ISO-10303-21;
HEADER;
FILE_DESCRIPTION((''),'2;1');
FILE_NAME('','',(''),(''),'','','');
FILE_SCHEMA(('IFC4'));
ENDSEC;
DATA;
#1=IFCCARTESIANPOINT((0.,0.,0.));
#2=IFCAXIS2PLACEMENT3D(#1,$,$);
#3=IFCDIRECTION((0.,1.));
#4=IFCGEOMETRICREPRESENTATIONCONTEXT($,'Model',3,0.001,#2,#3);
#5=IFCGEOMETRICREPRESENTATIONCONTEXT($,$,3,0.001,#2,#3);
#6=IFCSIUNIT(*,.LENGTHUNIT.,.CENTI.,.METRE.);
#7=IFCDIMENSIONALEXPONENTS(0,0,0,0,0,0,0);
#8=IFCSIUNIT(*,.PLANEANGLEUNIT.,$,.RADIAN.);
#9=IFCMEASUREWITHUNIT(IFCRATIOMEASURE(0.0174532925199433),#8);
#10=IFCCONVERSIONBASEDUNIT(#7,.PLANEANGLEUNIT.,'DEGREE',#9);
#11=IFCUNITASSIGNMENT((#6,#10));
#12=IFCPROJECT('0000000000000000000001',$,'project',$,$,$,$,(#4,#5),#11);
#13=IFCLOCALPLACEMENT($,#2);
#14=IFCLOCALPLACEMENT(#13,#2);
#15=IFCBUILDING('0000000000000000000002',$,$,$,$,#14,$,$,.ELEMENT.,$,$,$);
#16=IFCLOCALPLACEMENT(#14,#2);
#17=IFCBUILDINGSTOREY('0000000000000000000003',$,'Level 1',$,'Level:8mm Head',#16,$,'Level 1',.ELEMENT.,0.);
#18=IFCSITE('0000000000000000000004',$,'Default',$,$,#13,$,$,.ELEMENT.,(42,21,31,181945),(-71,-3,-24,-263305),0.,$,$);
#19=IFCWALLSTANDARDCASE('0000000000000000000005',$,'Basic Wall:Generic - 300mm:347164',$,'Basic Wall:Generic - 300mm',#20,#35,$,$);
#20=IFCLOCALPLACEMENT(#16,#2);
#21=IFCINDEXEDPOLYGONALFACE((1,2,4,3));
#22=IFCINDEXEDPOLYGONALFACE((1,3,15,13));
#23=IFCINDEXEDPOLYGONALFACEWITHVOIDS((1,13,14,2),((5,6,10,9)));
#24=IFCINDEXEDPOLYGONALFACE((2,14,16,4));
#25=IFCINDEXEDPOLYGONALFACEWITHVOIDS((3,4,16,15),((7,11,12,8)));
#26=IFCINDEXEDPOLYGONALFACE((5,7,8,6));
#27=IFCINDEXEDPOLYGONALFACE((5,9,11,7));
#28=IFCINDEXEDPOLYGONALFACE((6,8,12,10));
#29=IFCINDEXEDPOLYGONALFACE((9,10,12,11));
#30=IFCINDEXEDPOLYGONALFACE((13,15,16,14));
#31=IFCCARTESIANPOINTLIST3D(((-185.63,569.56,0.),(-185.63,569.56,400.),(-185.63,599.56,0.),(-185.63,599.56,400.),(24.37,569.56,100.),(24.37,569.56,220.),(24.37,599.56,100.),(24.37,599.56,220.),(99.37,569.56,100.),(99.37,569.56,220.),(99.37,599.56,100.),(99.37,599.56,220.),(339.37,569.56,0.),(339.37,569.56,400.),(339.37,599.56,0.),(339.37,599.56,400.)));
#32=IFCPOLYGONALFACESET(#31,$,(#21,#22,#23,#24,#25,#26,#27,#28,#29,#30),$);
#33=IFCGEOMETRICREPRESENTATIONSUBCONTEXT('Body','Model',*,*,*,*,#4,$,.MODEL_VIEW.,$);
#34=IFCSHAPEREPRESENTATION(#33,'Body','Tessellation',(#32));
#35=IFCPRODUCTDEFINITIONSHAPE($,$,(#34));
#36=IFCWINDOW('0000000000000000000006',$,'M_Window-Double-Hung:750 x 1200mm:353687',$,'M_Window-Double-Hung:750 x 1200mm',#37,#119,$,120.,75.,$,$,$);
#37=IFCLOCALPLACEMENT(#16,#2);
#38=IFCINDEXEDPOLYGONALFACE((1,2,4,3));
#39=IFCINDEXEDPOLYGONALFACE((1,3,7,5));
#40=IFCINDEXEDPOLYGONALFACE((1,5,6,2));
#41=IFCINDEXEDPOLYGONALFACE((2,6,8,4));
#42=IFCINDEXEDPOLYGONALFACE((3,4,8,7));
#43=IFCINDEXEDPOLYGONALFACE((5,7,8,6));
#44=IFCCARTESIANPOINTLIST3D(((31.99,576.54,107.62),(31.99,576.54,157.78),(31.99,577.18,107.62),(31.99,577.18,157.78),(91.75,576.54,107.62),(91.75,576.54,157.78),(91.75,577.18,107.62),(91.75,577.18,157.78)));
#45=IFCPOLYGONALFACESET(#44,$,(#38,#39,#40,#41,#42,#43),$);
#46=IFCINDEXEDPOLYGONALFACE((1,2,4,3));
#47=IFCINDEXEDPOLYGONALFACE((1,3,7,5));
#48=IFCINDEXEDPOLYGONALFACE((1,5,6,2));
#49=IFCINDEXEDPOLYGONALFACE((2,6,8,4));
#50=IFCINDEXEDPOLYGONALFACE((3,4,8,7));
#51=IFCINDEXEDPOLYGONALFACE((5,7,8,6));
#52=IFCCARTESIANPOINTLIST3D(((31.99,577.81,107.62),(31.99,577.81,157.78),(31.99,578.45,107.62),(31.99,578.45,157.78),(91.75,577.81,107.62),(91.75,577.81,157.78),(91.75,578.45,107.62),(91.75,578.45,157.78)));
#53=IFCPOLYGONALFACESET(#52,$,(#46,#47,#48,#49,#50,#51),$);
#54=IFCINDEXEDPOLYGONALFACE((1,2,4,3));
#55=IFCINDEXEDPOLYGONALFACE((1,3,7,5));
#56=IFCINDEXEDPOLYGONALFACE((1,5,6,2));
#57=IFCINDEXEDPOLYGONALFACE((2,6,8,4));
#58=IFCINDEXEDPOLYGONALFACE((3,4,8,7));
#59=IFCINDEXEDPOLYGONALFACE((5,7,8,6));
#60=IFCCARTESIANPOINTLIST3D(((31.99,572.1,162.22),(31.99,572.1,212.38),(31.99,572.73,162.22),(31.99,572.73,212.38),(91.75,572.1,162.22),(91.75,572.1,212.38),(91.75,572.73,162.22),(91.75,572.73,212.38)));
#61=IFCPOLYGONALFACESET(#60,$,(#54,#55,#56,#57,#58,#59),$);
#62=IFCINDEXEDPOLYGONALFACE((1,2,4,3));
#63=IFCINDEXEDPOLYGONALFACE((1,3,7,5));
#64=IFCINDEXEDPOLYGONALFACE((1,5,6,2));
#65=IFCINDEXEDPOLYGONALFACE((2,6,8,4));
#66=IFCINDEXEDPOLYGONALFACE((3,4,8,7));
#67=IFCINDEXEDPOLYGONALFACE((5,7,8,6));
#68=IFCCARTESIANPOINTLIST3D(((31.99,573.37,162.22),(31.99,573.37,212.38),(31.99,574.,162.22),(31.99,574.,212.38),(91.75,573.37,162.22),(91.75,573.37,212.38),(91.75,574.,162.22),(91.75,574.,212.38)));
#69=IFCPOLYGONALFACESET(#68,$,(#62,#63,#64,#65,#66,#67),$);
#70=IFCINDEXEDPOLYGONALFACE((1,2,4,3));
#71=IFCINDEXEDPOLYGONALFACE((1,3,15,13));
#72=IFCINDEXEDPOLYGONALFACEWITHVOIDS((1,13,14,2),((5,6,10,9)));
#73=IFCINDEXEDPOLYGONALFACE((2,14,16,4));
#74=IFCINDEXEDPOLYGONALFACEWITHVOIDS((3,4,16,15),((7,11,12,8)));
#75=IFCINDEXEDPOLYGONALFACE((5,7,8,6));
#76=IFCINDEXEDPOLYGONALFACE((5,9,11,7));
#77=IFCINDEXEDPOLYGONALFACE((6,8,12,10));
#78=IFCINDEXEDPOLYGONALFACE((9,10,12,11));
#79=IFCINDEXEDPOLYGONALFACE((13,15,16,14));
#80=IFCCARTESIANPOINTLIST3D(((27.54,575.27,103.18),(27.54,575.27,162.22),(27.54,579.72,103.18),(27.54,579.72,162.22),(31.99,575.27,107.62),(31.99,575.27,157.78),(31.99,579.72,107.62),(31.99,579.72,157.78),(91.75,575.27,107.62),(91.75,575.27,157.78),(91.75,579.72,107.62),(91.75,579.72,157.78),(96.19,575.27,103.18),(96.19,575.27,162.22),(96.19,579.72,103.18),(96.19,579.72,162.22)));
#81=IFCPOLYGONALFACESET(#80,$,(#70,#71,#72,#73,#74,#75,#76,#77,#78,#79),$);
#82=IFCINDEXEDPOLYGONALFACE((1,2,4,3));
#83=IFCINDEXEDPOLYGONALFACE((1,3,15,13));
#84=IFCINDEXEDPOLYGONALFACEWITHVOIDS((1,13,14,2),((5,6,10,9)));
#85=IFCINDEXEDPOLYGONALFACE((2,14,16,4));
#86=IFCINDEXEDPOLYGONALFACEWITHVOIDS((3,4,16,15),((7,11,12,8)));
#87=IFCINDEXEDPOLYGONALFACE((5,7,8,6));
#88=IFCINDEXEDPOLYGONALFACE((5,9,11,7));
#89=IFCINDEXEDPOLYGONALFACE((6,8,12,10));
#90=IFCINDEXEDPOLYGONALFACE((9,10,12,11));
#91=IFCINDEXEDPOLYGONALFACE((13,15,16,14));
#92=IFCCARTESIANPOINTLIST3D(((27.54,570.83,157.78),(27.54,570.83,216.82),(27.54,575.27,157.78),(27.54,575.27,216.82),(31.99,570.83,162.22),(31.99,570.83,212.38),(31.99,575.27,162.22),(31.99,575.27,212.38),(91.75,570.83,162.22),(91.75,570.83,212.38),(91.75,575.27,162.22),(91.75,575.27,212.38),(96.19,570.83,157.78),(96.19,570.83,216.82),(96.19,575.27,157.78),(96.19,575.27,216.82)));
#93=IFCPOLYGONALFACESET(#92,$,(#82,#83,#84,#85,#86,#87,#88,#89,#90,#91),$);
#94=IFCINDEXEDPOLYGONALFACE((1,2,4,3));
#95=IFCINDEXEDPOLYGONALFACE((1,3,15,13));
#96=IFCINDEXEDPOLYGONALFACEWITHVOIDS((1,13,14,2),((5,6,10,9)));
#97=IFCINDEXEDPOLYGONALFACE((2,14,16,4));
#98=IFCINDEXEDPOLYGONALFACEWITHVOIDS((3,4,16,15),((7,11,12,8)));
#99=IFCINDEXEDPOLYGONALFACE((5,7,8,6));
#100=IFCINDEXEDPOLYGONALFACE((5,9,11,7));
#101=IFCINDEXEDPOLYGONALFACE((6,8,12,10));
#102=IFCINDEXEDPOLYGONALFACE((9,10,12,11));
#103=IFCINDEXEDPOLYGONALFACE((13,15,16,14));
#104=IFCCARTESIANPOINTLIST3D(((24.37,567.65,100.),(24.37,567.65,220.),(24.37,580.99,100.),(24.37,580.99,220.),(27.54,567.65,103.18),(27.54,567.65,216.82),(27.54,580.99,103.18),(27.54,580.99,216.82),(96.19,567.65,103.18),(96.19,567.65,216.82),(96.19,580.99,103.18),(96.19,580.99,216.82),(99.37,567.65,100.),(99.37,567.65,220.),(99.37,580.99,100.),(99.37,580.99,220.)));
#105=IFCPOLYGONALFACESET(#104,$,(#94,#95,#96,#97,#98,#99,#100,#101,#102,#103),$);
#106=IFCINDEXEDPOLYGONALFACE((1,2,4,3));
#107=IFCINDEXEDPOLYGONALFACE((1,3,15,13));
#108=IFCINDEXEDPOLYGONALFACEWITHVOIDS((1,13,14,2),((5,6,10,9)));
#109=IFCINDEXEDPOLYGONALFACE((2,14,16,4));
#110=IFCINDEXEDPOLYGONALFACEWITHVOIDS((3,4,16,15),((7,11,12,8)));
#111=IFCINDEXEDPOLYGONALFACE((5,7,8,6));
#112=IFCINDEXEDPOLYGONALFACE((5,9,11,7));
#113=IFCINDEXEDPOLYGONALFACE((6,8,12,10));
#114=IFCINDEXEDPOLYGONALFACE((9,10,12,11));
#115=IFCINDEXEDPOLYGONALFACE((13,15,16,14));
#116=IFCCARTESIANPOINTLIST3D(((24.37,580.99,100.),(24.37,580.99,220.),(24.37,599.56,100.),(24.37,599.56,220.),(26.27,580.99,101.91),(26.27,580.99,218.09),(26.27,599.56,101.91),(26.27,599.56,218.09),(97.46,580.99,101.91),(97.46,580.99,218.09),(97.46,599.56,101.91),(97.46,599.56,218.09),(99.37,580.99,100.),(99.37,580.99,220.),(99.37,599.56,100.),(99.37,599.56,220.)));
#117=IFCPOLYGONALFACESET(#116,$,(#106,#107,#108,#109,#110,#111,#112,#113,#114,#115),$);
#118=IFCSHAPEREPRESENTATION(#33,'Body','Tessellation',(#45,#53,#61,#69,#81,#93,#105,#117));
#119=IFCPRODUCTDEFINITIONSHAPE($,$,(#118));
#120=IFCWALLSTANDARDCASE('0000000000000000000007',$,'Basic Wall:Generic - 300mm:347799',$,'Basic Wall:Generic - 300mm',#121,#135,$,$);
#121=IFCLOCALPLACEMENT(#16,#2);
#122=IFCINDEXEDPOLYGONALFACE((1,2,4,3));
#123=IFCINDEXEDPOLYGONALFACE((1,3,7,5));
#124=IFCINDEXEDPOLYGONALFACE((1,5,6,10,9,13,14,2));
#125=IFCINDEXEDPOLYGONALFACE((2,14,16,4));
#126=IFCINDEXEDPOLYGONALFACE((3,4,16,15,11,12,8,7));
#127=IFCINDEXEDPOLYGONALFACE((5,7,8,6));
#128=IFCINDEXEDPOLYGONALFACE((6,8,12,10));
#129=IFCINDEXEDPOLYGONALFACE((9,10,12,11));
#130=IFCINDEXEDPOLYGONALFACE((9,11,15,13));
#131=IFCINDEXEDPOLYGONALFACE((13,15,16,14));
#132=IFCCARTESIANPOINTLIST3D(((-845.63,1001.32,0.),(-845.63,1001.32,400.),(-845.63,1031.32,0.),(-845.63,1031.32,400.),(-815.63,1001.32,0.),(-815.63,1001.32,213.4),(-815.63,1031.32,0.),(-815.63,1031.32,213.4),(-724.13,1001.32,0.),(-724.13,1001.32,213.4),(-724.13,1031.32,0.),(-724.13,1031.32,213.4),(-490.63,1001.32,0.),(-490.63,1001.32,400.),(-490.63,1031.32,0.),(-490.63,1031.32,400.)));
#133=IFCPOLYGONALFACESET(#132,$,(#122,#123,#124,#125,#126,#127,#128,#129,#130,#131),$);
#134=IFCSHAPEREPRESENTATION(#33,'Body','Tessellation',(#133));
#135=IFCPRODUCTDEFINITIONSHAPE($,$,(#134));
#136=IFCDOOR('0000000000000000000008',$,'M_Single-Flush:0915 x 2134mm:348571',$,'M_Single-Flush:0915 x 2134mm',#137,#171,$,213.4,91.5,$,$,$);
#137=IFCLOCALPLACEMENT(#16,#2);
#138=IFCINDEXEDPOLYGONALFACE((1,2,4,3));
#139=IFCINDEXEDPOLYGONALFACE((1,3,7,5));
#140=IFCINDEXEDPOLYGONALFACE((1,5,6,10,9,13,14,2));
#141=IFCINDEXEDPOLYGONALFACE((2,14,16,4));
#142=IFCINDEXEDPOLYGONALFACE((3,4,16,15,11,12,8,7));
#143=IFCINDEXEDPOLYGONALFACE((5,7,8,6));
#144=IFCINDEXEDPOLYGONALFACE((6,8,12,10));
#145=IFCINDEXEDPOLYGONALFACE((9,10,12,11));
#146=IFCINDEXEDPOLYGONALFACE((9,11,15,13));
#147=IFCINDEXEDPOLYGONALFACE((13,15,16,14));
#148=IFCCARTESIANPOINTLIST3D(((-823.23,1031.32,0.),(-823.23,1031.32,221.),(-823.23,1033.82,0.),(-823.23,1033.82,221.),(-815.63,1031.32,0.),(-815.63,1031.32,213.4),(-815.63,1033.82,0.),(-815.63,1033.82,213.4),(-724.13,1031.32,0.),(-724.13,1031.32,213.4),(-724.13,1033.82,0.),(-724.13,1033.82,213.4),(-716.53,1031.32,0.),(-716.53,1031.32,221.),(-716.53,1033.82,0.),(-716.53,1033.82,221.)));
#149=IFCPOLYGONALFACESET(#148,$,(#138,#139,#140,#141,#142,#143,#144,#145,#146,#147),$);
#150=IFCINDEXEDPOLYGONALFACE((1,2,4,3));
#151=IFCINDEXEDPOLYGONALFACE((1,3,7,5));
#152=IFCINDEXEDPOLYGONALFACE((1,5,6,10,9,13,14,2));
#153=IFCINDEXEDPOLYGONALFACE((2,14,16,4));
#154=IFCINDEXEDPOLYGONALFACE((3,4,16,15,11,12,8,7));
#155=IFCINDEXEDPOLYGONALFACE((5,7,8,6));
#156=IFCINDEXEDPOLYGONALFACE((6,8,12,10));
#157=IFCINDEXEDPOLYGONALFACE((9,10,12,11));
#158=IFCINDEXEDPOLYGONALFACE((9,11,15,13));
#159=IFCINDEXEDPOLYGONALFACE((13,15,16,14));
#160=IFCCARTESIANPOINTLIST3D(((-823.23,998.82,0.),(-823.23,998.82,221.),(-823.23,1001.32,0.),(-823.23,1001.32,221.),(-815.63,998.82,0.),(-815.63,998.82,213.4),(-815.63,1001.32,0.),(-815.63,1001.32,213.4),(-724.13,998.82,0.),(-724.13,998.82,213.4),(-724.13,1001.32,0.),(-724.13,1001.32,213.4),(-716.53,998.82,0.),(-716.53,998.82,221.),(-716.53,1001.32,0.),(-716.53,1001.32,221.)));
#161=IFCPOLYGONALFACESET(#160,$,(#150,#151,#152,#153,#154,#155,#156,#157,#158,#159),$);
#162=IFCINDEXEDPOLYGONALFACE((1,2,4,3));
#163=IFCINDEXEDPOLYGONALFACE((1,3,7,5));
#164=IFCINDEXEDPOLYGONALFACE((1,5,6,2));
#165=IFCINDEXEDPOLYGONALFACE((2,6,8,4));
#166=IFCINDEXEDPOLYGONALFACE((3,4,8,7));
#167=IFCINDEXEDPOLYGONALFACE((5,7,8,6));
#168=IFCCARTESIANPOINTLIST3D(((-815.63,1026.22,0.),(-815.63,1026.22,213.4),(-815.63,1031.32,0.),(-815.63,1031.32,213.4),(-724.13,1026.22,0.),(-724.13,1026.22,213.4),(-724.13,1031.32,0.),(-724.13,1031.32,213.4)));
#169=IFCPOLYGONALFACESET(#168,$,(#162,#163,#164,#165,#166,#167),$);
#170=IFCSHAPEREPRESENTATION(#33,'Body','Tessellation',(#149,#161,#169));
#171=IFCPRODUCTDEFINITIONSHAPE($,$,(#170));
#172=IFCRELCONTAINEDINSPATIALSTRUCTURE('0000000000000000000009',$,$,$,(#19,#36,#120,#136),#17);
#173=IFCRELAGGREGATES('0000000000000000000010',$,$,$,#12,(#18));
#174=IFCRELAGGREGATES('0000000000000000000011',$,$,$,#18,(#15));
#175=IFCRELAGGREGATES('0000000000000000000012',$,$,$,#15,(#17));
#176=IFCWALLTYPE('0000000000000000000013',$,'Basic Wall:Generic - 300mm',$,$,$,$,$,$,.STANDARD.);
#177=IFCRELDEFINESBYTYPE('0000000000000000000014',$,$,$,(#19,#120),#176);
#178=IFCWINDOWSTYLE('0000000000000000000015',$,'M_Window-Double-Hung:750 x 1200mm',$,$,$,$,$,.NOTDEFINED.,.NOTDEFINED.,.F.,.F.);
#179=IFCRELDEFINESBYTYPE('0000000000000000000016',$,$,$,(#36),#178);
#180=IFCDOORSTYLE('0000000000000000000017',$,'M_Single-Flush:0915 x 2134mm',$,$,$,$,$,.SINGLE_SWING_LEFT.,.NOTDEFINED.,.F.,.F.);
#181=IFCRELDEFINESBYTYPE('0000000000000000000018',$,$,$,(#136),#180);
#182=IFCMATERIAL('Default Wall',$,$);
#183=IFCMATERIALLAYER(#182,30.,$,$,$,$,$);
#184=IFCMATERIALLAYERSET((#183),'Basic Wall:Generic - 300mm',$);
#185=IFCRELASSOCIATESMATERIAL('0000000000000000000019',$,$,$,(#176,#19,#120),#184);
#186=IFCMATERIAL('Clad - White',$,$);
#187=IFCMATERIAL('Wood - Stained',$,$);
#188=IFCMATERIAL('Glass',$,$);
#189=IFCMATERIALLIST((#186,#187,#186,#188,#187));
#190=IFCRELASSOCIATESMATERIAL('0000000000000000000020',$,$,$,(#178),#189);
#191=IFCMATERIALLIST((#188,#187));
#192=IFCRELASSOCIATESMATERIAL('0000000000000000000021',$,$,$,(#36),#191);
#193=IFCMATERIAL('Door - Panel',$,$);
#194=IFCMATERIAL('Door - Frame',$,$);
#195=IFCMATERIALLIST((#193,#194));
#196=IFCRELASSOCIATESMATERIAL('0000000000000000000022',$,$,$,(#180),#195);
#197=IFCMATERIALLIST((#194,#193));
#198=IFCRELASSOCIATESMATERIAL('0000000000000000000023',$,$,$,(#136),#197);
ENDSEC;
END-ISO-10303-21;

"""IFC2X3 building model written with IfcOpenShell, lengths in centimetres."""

from ifc_helpers import new_model, entity, si_unit, converted_unit, direction, frame, frame_2d, origin, origin_2d_with_axis, place, context, subcontext, project, spatial, polyline, rectangle, outline, extrude, source, transform, mapped, material, material_list, layer, layer_set, layer_usage, type_object, type_shapes, element, fill, save


model = new_model("IFC2X3")

# Units and contexts
model_context = context("Model", 3, precision=0.001, world=origin(), true_north=direction((0.0, 1.0)))
context_of_model = context(None, 3, precision=0.001, world=origin(), true_north=direction((0.0, 1.0)))
body_context = subcontext(model_context, "Body", "Model", "MODEL_VIEW")
ifc_project = project(units=[si_unit("LENGTHUNIT", "METRE", prefix="CENTI"), converted_unit("PLANEANGLEUNIT", "DEGREE", entity("IfcRatioMeasure", 0.0174532925199433), si_unit("PLANEANGLEUNIT", "RADIAN"), dimensions=[0, 0, 0, 0, 0, 0, 0])], contexts=[model_context, context_of_model])

# Site, building, storey
site_placement = place(None, origin())
site = spatial("IfcSite", under=ifc_project, at=site_placement, Name="Default", CompositionType="ELEMENT", RefLatitude=(42, 21, 31, 181945), RefLongitude=(-71, -3, -24, -263305), RefElevation=0.0)
building_placement = place(site_placement, origin())
building = spatial("IfcBuilding", under=site, at=building_placement, CompositionType="ELEMENT")
storey_placement = place(building_placement, origin())
storey = spatial("IfcBuildingStorey", under=building, at=storey_placement, Name="Level 1", ObjectType="Level:8mm Head", LongName="Level 1", CompositionType="ELEMENT", Elevation=0.0)

# Wall, opening, window
ifc_material_1 = material(Name="Default Wall")
ifc_layer_1 = layer(ifc_material_1, 30.0)
ifc_layer_set_1 = layer_set([ifc_layer_1], Name="Basic Wall:Generic - 300mm")
wall_type = type_object("IfcWallType", Name="Basic Wall:Generic - 300mm", PredefinedType="STANDARD", material=ifc_layer_set_1)
ifc_material_2 = material(Name="Glass")
ifc_material_3 = material(Name="Wood - Stained")
ifc_material_4 = material(Name="Clad - White")
ifc_material_list_1 = material_list([ifc_material_4, ifc_material_3, ifc_material_4, ifc_material_2, ifc_material_3])
window_style = type_object("IfcWindowStyle", Name="M_Window-Double-Hung:750 x 1200mm", ConstructionType="NOTDEFINED", OperationType="NOTDEFINED", ParameterTakesPrecedence=False, Sizeable=False, material=ifc_material_list_1)
shared_shape_1 = source(origin(), body_context, "Body", "SweptSolid", [
    extrude(rectangle(XDim=59.76, YDim=0.63, at=frame_2d((0.0, 0.0), x_axis=(1.0, 0.0))), frame((37.5, 22.7, 7.62), z_axis=(0.0, 0.0, 1.0), x_axis=(-1.0, 0.0, 0.0)), (0.0, 0.0, 1.0), 50.16),
    extrude(rectangle(XDim=0.63, YDim=59.76, at=origin_2d_with_axis()), frame((37.5, 21.43, 7.62), z_axis=(0.0, 0.0, 1.0), x_axis=(0.0, -1.0, 0.0)), (0.0, 0.0, 1.0), 50.16),
    extrude(rectangle(XDim=59.76, YDim=0.63, at=frame_2d((0.0, 0.0), x_axis=(1.0, 0.0))), frame((37.5, 27.14, 62.22), z_axis=(0.0, 0.0, 1.0), x_axis=(-1.0, 0.0, 0.0)), (0.0, 0.0, 1.0), 50.16),
    extrude(rectangle(XDim=0.63, YDim=59.76, at=frame_2d((0.0, 0.0), x_axis=(1.0, 0.0))), frame((37.5, 25.87, 62.22), z_axis=(0.0, 0.0, 1.0), x_axis=(0.0, -1.0, 0.0)), (0.0, 0.0, 1.0), 50.16),
    extrude(outline(polyline([(-34.32, -29.52), (34.32, -29.52), (34.32, 29.52), (-34.32, 29.52), (-34.32, -29.52)]), holes=[polyline([(29.88, -25.08), (-29.88, -25.08), (-29.88, 25.08), (29.88, 25.08), (29.88, -25.08)])]), frame((37.5, 19.84, 32.7), z_axis=(0.0, 1.0, 0.0), x_axis=(1.0, 0.0, 0.0)), (0.0, 0.0, 1.0), 4.45),
    extrude(outline(polyline([(-34.33, -29.52), (34.32, -29.52), (34.33, 29.52), (-34.32, 29.52), (-34.33, -29.52)]), holes=[polyline([(29.88, -25.08), (-29.88, -25.08), (-29.88, 25.08), (29.88, 25.08), (29.88, -25.08)])]), frame((37.5, 24.28, 87.3), z_axis=(0.0, 1.0, 0.0), x_axis=(1.0, 0.0, 0.0)), (0.0, 0.0, 1.0), 4.45),
    extrude(outline(polyline([(-37.5, -60.0), (37.5, -60.0), (37.5, 60.0), (-37.5, 60.0), (-37.5, -60.0)]), holes=[polyline([(34.32, -56.82), (-34.32, -56.82), (-34.32, 56.82), (34.32, 56.82), (34.32, -56.82)])]), frame((37.5, 18.57, 60.0), z_axis=(0.0, 1.0, 0.0), x_axis=(1.0, 0.0, 0.0)), (0.0, 0.0, 1.0), 13.33),
    extrude(outline(polyline([(-60.0, -37.5), (60.0, -37.5), (60.0, 37.5), (-60.0, 37.5), (-60.0, -37.5)]), holes=[polyline([(-58.09, -35.59), (-58.09, 35.59), (58.09, 35.59), (58.09, -35.59), (-58.09, -35.59)])]), frame((37.5, 0.0, 60.0), z_axis=(0.0, 1.0, 0.0), x_axis=(0.0, 0.0, -1.0)), (0.0, 0.0, 1.0), 18.57),
])
type_shapes(window_style, [shared_shape_1])
ifc_layer_usage_1 = layer_usage(ifc_layer_set_1, "AXIS2", "NEGATIVE", 15.0)
wall_1_placement = place(storey_placement, frame((339.37, 584.56, 0.0), z_axis=(0.0, 0.0, 1.0), x_axis=(-1.0, 0.0, 0.0)))
wall_1 = element("IfcWallStandardCase", 1, at=wall_1_placement, inside=storey, type_object=wall_type, material=ifc_layer_usage_1, Name="Basic Wall:Generic - 300mm:347164", ObjectType="Basic Wall:Generic - 300mm", context=body_context, shape_type="SweptSolid", body=[
    extrude(rectangle(XDim=525.0, YDim=30.0, at=frame_2d((262.5, 0.0), x_axis=(-1.0, 0.0))), origin(), (0.0, 0.0, 1.0), 400.0),
])
opening_1_placement = place(wall_1_placement, frame((240.0, -15.0, 100.0)))
opening_1 = element("IfcOpeningElement", 2, at=opening_1_placement, cuts=wall_1, ObjectType="Opening", context=body_context, shape_type="SweptSolid", body=[
    extrude(rectangle(XDim=120.0, YDim=75.0, at=frame_2d((60.0, 37.5), x_axis=(-1.0, 0.0))), frame((0.0, 0.0, 0.0), z_axis=(0.0, 1.0, 0.0), x_axis=(0.0, 0.0, 1.0)), (0.0, 0.0, 1.0), 30.0),
])
ifc_material_list_2 = material_list([ifc_material_2, ifc_material_3])
window_1_placement = place(opening_1_placement, origin())
window_1 = element("IfcWindow", 3, at=window_1_placement, inside=storey, type_object=window_style, material=ifc_material_list_2, Name="M_Window-Double-Hung:750 x 1200mm:353687", ObjectType="M_Window-Double-Hung:750 x 1200mm", OverallHeight=120.0, OverallWidth=75.0, context=body_context, shape_type="MappedRepresentation", body=[
    mapped(shared_shape_1, transform((0.0, 0.0, 0.0), scale=1.0)),
])
fill(opening_1, window_1)

# Wall, opening, door
ifc_layer_usage_2 = layer_usage(ifc_layer_set_1, "AXIS2", "POSITIVE", -15.0)
wall_2_placement = place(storey_placement, frame((-845.63, 1016.32, 0.0)))
wall_2 = element("IfcWallStandardCase", 4, at=wall_2_placement, inside=storey, type_object=wall_type, material=ifc_layer_usage_2, Name="Basic Wall:Generic - 300mm:347799", ObjectType="Basic Wall:Generic - 300mm", context=body_context, shape_type="SweptSolid", body=[
    extrude(rectangle(XDim=355.0, YDim=30.0, at=frame_2d((177.5, 0.0), x_axis=(-1.0, 0.0))), origin(), (0.0, 0.0, 1.0), 400.0),
])
opening_2_placement = place(wall_2_placement, frame((30.0, -15.0, 0.0)))
opening_2 = element("IfcOpeningElement", 5, at=opening_2_placement, cuts=wall_2, ObjectType="Opening", context=body_context, shape_type="SweptSolid", body=[
    extrude(rectangle(XDim=91.5, YDim=213.4, at=frame_2d((106.7, 45.75), x_axis=(0.0, -1.0))), frame((0.0, 0.0, 0.0), z_axis=(0.0, 1.0, 0.0), x_axis=(0.0, 0.0, 1.0)), (0.0, 0.0, 1.0), 30.0),
])
ifc_material_5 = material(Name="Door - Frame")
ifc_material_6 = material(Name="Door - Panel")
ifc_material_list_3 = material_list([ifc_material_5, ifc_material_6])
ifc_material_list_4 = material_list([ifc_material_6, ifc_material_5])
door_style = type_object("IfcDoorStyle", Name="M_Single-Flush:0915 x 2134mm", ConstructionType="NOTDEFINED", OperationType="SINGLE_SWING_LEFT", ParameterTakesPrecedence=False, Sizeable=False, material=ifc_material_list_4)
shared_shape_2 = source(origin(), body_context, "Body", "SweptSolid", [
    extrude(outline(polyline([(-53.35, -112.4), (53.35, -112.4), (53.35, 108.6), (45.75, 108.6), (45.75, -104.8), (-45.75, -104.8), (-45.75, 108.6), (-53.35, 108.6), (-53.35, -112.4)])), frame((45.75, 32.5, 108.6), z_axis=(0.0, -1.0, 0.0), x_axis=(-1.0, 0.0, 0.0)), (0.0, 0.0, 1.0), 2.5),
    extrude(outline(polyline([(-112.4, -53.35), (108.6, -53.35), (108.6, -45.75), (-104.8, -45.75), (-104.8, 45.75), (108.6, 45.75), (108.6, 53.35), (-112.4, 53.35), (-112.4, -53.35)])), frame((45.75, 0.0, 108.6), z_axis=(0.0, -1.0, 0.0), x_axis=(0.0, 0.0, -1.0)), (0.0, 0.0, 1.0), 2.5),
    extrude(rectangle(XDim=91.5, YDim=5.1, at=frame_2d((0.0, 0.0), x_axis=(1.0, 0.0))), frame((45.75, 27.45, 0.0)), (0.0, 0.0, 1.0), 213.4),
])
type_shapes(door_style, [shared_shape_2])
door_placement = place(opening_2_placement, origin())
door = element("IfcDoor", 6, at=door_placement, inside=storey, type_object=door_style, material=ifc_material_list_3, Name="M_Single-Flush:0915 x 2134mm:348571", ObjectType="M_Single-Flush:0915 x 2134mm", OverallHeight=213.4, OverallWidth=91.5, context=body_context, shape_type="MappedRepresentation", body=[
    mapped(shared_shape_2, transform((0.0, 0.0, 0.0), scale=1.0)),
])
fill(opening_2, door)

save(model, "model.ifc")
